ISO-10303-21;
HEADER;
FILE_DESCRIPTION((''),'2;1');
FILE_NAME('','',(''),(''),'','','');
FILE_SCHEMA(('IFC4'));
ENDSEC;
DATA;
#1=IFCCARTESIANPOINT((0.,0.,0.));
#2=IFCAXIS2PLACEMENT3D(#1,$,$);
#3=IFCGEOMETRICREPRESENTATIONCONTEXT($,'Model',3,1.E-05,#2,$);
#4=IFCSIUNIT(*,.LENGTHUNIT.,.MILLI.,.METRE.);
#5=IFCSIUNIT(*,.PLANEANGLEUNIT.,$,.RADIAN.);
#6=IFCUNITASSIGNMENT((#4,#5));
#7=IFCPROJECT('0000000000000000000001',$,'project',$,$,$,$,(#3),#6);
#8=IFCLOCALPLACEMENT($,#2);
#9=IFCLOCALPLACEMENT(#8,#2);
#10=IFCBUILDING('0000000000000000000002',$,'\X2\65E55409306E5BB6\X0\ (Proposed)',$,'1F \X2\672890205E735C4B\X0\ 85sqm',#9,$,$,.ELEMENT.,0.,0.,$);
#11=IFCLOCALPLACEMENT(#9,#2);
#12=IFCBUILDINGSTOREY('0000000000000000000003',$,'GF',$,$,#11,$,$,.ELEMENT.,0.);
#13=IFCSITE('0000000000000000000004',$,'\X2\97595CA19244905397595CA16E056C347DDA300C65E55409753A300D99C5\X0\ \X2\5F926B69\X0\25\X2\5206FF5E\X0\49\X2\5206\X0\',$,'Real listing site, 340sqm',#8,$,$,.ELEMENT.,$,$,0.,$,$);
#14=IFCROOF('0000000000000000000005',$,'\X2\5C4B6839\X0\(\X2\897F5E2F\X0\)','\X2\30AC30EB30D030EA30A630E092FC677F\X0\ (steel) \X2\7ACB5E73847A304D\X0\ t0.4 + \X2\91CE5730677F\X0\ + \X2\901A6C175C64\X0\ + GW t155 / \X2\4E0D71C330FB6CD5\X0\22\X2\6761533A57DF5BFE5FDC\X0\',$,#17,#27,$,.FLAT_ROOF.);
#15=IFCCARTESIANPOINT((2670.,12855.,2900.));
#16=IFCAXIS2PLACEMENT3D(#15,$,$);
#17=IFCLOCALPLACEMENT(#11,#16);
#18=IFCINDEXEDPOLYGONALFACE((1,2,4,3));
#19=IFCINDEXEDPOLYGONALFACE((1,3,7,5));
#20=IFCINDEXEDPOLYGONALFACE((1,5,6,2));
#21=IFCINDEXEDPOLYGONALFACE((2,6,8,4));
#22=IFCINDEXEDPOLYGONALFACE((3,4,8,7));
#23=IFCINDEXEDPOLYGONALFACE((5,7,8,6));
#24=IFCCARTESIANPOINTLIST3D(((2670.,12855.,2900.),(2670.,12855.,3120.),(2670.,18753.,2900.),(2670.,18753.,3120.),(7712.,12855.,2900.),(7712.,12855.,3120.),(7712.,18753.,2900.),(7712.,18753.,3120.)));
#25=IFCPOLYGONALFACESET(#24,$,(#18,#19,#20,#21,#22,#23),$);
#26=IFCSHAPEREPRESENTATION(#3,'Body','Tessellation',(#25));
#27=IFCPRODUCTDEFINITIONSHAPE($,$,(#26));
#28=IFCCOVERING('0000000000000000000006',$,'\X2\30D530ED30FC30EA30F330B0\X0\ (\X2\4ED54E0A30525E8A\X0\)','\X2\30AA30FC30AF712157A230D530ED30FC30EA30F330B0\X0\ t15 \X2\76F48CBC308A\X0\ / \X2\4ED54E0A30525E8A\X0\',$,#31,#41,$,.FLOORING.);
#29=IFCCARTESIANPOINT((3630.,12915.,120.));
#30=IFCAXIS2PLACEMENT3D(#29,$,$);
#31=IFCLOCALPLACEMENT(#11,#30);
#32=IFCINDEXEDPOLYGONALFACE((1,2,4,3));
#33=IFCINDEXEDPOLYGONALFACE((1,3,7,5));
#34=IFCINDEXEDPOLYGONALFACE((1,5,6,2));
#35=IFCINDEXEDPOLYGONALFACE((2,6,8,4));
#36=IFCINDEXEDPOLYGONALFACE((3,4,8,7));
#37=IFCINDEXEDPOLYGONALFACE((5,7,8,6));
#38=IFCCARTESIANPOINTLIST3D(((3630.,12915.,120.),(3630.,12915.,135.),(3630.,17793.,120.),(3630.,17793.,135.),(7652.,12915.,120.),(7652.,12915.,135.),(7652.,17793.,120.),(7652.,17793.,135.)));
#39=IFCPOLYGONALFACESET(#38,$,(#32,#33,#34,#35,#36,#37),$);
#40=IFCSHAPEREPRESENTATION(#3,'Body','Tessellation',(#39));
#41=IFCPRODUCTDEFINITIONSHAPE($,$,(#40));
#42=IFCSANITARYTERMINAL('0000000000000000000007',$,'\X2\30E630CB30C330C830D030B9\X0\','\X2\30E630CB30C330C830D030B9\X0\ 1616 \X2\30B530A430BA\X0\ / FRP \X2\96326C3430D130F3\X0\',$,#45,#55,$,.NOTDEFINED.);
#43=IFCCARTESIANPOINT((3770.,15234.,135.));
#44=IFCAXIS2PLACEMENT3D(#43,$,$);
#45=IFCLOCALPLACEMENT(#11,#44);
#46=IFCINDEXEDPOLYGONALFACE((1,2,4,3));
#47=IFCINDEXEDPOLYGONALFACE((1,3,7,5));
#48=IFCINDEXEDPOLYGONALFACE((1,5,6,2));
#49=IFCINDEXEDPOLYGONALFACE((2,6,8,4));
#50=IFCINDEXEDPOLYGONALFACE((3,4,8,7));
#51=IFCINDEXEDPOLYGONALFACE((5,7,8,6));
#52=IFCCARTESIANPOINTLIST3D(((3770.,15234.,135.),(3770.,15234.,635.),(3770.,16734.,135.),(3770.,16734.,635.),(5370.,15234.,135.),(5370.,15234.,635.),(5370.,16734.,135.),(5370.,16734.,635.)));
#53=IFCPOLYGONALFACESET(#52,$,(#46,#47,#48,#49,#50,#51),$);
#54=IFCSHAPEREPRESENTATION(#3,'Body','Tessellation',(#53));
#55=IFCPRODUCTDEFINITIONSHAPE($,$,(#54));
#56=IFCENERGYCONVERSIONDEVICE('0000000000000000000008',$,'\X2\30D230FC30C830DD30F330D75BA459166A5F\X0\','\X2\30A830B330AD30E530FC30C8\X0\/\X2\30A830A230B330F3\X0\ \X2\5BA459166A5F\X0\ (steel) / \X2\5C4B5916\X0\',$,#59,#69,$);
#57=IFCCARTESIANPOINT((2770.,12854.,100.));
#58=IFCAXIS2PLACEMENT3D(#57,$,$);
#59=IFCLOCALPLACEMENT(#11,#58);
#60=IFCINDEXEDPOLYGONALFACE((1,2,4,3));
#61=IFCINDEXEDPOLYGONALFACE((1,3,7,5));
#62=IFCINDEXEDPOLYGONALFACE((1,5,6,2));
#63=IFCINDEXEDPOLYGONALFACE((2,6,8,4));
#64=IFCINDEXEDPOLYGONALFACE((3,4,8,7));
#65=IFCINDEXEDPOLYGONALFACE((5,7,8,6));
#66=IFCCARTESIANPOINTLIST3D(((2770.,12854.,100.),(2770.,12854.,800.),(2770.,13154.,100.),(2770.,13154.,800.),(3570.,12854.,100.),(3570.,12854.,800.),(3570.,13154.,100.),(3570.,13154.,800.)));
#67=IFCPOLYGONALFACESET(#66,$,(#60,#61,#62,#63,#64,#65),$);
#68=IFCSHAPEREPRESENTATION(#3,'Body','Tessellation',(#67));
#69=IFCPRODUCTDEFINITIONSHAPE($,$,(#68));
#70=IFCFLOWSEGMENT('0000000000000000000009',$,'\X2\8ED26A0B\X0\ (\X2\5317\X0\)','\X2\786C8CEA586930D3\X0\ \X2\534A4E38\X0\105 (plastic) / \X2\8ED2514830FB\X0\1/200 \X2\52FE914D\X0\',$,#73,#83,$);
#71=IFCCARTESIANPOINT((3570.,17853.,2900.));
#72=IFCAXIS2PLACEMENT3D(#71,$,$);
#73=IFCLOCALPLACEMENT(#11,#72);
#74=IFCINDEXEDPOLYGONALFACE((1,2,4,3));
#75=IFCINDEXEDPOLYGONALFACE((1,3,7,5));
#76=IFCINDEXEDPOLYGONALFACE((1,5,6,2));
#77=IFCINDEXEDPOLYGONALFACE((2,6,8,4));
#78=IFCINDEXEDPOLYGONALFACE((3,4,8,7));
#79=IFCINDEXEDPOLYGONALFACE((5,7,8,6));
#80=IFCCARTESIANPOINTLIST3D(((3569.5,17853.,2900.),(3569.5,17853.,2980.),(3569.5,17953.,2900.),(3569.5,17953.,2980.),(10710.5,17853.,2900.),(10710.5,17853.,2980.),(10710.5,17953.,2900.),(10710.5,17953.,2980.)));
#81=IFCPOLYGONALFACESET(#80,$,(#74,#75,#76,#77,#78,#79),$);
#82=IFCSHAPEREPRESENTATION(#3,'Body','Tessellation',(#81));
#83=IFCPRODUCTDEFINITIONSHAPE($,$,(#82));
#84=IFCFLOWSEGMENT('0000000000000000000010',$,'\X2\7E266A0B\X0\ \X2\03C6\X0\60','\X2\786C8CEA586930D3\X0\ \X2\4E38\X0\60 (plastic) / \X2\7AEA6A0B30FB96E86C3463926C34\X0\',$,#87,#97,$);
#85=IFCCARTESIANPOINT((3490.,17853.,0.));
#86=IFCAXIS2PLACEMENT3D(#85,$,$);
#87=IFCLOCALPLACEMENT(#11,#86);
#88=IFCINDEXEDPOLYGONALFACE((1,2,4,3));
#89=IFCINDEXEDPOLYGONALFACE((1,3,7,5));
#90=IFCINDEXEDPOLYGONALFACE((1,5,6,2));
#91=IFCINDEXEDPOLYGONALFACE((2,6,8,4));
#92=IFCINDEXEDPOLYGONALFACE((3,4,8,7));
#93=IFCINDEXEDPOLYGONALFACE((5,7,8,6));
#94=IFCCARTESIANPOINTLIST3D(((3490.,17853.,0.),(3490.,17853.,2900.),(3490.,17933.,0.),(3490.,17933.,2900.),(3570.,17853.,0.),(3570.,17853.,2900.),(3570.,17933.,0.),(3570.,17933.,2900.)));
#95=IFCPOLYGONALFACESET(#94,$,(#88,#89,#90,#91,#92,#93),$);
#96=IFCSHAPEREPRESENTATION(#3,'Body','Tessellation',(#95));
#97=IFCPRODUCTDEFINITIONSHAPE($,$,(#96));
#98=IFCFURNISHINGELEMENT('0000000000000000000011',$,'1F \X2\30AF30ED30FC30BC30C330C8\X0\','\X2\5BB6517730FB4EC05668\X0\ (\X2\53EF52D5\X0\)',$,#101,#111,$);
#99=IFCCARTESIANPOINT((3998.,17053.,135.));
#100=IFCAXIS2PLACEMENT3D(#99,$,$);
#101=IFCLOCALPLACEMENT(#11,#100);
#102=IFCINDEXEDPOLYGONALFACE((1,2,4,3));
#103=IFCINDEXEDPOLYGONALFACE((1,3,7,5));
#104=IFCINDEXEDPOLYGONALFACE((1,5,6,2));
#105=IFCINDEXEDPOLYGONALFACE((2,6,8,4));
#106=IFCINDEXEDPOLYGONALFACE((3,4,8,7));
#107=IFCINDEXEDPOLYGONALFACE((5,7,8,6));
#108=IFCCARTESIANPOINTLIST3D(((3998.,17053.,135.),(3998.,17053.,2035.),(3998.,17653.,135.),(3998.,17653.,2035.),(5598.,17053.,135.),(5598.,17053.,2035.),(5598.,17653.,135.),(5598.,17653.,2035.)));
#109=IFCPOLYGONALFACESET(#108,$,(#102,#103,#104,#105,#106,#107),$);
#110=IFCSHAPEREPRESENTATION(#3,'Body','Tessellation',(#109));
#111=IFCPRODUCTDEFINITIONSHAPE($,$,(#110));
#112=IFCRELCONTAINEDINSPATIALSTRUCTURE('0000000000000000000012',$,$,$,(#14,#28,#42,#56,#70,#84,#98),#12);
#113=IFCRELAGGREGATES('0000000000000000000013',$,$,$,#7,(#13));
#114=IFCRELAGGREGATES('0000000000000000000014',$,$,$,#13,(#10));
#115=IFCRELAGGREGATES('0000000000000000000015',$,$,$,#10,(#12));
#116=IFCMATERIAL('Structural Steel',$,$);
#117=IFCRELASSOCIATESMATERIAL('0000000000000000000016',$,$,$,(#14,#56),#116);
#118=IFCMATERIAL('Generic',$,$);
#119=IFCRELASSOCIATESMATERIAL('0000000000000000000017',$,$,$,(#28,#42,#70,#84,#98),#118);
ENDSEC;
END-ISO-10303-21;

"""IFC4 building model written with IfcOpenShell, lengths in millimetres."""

from ifc_helpers import new_model, si_unit, frame, frame_2d, origin, place, context, project, spatial, rectangle, extrude, material, element, save


model = new_model("IFC4")

# Units and contexts
model_context = context("Model", 3, precision=1e-05, world=origin())
ifc_project = project(units=[si_unit("LENGTHUNIT", "METRE", prefix="MILLI"), si_unit("PLANEANGLEUNIT", "RADIAN")], contexts=[model_context])

# Site, building, storey
site_placement = place(None, origin())
site = spatial("IfcSite", under=ifc_project, at=site_placement, Name="静岡鉄道静岡清水線「日吉町」駅 徒歩25分～49分", ObjectType="Real listing site, 340sqm", CompositionType="ELEMENT", RefElevation=0.0)
building_placement = place(site_placement, origin())
building = spatial("IfcBuilding", under=site, at=building_placement, Name="日吉の家 (Proposed)", ObjectType="1F 木造平屋 85sqm", CompositionType="ELEMENT", ElevationOfRefHeight=0.0, ElevationOfTerrain=0.0)
storey_placement = place(building_placement, origin())
storey = spatial("IfcBuildingStorey", under=building, at=storey_placement, Name="GF", CompositionType="ELEMENT", Elevation=0.0)

# Roof
ifc_material_1 = material(Name="Structural Steel")
roof_placement = place(storey_placement, frame((2670.0, 12855.0, 2900.0)))
element("IfcRoof", 1, at=roof_placement, inside=storey, material=ifc_material_1, Name="屋根(西帯)", Description="ガルバリウム鋼板 (steel) 立平葺き t0.4 + 野地板 + 通気層 + GW t155 / 不燃・法22条区域対応", PredefinedType="FLAT_ROOF", context=model_context, shape_type="SweptSolid", body=[
    extrude(rectangle(XDim=5042.0, YDim=5898.0, at=frame_2d((2521.0, 2949.0))), frame((2670.0, 12855.0, 2900.0)), (0.0, 0.0, 1.0), 220.0),
])

# Covering
ifc_material_2 = material(Name="Generic")
covering_placement = place(storey_placement, frame((3630.0, 12915.0, 120.0)))
element("IfcCovering", 2, at=covering_placement, inside=storey, material=ifc_material_2, Name="フローリング (仕上げ床)", Description="オーク無垢フローリング t15 直貼り / 仕上げ床", PredefinedType="FLOORING", context=model_context, shape_type="SweptSolid", body=[
    extrude(rectangle(XDim=4022.0, YDim=4878.0, at=frame_2d((2011.0, 2439.0))), frame((3630.0, 12915.0, 120.0)), (0.0, 0.0, 1.0), 15.0),
])

# Sanitary terminal
sanitary_terminal_placement = place(storey_placement, frame((3770.0, 15234.0, 135.0)))
element("IfcSanitaryTerminal", 3, at=sanitary_terminal_placement, inside=storey, material=ifc_material_2, Name="ユニットバス", Description="ユニットバス 1616 サイズ / FRP 防水パン", PredefinedType="NOTDEFINED", context=model_context, shape_type="SweptSolid", body=[
    extrude(rectangle(XDim=1600.0, YDim=1500.0, at=frame_2d((800.0, 750.0))), frame((3770.0, 15234.0, 135.0)), (0.0, 0.0, 1.0), 500.0),
])

# Energy conversion device
energy_conversion_device_placement = place(storey_placement, frame((2770.0, 12854.0, 100.0)))
element("IfcEnergyConversionDevice", 4, at=energy_conversion_device_placement, inside=storey, material=ifc_material_1, Name="ヒートポンプ室外機", Description="エコキュート/エアコン 室外機 (steel) / 屋外", context=model_context, shape_type="SweptSolid", body=[
    extrude(rectangle(XDim=800.0, YDim=300.0, at=frame_2d((400.0, 150.0))), frame((2770.0, 12854.0, 100.0)), (0.0, 0.0, 1.0), 700.0),
])

# Flow segments
flow_segment_1_placement = place(storey_placement, frame((3570.0, 17853.0, 2900.0)))
element("IfcFlowSegment", 5, at=flow_segment_1_placement, inside=storey, material=ifc_material_2, Name="軒樋 (北)", Description="硬質塩ビ 半丸105 (plastic) / 軒先・1/200 勾配", context=model_context, shape_type="SweptSolid", body=[
    extrude(rectangle(XDim=7141.0, YDim=100.0, at=frame_2d((3570.0, 50.0))), frame((3570.0, 17853.0, 2900.0)), (0.0, 0.0, 1.0), 80.0),
])
flow_segment_2_placement = place(storey_placement, frame((3490.0, 17853.0, 0.0)))
element("IfcFlowSegment", 6, at=flow_segment_2_placement, inside=storey, material=ifc_material_2, Name="縦樋 φ60", Description="硬質塩ビ 丸60 (plastic) / 竪樋・雨水排水", context=model_context, shape_type="SweptSolid", body=[
    extrude(rectangle(XDim=80.0, YDim=80.0, at=frame_2d((40.0, 40.0))), frame((3490.0, 17853.0, 0.0)), (0.0, 0.0, 1.0), 2900.0),
])

# Furnishing element
furnishing_placement = place(storey_placement, frame((3998.0, 17053.0, 135.0)))
element("IfcFurnishingElement", 7, at=furnishing_placement, inside=storey, material=ifc_material_2, Name="1F クローゼット", Description="家具・什器 (可動)", context=model_context, shape_type="SweptSolid", body=[
    extrude(rectangle(XDim=1600.0, YDim=600.0, at=frame_2d((800.0, 300.0))), frame((3998.0, 17053.0, 135.0)), (0.0, 0.0, 1.0), 1900.0),
])

save(model, "model.ifc")
